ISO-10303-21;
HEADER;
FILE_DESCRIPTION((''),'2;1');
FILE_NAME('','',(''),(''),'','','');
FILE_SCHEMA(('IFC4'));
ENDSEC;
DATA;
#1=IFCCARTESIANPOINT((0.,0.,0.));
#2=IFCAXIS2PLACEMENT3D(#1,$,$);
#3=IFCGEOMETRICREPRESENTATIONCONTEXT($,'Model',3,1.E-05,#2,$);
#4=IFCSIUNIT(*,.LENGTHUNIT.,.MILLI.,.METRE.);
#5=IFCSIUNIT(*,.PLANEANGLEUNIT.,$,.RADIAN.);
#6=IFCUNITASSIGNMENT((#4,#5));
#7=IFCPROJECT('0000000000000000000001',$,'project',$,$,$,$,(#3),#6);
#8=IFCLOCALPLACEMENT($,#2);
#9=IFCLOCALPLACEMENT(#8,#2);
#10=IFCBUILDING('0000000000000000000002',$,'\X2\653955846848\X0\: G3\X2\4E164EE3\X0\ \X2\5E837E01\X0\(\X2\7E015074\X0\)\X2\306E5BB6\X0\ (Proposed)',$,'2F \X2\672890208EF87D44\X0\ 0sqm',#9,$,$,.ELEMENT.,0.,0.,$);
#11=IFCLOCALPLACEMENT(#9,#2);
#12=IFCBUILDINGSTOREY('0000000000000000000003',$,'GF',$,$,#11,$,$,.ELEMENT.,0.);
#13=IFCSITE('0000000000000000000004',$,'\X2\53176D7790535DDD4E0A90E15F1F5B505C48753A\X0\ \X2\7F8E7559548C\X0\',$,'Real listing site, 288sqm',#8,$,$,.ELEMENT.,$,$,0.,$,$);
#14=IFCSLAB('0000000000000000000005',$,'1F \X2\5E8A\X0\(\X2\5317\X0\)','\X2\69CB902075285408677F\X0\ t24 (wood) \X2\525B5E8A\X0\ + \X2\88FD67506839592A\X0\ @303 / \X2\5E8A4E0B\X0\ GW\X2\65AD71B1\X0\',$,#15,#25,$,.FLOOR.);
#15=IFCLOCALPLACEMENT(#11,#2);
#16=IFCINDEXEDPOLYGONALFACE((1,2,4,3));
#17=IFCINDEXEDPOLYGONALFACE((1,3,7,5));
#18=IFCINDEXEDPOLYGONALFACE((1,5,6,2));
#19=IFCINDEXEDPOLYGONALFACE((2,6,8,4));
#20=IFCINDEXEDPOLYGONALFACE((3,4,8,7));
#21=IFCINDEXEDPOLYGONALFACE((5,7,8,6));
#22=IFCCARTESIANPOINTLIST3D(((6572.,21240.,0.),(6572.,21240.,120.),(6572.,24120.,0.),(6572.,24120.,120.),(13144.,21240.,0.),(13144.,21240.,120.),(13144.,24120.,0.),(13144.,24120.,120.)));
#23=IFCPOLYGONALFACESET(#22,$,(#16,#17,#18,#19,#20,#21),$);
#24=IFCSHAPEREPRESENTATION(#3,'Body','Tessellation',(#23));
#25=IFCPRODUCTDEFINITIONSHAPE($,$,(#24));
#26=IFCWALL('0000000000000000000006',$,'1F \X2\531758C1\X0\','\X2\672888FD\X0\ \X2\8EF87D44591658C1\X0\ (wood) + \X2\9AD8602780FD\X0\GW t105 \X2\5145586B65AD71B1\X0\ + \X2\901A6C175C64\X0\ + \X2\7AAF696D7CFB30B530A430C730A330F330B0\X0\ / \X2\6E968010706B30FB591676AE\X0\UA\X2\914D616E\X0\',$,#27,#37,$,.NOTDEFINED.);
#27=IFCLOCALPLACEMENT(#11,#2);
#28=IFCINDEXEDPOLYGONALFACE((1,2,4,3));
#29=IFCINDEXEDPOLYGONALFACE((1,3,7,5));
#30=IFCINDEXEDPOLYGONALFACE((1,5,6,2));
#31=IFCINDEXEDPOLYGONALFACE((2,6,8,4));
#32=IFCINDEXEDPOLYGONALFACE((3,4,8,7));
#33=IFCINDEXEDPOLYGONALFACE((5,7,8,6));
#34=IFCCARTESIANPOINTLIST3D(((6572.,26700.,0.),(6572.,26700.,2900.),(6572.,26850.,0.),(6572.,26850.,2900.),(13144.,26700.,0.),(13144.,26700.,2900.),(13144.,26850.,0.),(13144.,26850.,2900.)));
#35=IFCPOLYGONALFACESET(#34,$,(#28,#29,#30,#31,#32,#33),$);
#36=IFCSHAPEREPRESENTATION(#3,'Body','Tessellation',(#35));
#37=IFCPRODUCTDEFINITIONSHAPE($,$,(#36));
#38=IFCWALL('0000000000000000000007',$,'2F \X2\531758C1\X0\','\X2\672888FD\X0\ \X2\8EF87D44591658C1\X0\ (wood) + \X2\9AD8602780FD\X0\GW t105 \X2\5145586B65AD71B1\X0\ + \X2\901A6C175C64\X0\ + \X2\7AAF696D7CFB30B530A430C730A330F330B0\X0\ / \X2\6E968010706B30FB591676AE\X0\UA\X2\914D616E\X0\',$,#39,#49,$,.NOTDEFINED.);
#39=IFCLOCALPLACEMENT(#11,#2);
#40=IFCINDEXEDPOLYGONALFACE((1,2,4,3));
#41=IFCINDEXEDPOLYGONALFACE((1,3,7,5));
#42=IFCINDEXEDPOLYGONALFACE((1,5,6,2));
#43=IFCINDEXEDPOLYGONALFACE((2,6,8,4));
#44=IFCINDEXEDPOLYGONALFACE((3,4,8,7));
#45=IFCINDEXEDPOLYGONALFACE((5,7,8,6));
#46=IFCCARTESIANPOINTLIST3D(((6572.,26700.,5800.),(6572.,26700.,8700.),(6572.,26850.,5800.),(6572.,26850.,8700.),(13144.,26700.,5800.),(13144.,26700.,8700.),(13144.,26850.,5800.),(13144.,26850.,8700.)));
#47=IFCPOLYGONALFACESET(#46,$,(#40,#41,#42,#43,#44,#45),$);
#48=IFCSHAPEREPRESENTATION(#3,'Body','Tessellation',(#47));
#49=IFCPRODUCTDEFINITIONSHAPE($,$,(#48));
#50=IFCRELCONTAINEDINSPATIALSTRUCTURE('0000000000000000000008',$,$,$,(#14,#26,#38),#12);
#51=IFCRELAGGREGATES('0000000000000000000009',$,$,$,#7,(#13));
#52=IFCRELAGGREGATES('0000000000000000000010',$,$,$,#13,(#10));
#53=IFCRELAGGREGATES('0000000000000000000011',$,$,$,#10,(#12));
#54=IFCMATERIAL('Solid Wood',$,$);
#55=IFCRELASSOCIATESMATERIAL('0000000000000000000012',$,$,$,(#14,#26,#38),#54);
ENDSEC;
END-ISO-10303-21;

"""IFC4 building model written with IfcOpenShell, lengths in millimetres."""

from ifc_helpers import new_model, si_unit, frame, frame_2d, origin, place, context, project, spatial, rectangle, extrude, material, element, save


model = new_model("IFC4")

# Units and contexts
model_context = context("Model", 3, precision=1e-05, world=origin())
ifc_project = project(units=[si_unit("LENGTHUNIT", "METRE", prefix="MILLI"), si_unit("PLANEANGLEUNIT", "RADIAN")], contexts=[model_context])

# Site, building, storey
site_placement = place(None, origin())
site = spatial("IfcSite", under=ifc_project, at=site_placement, Name="北海道川上郡弟子屈町 美留和", ObjectType="Real listing site, 288sqm", CompositionType="ELEMENT", RefElevation=0.0)
building_placement = place(site_placement, origin())
building = spatial("IfcBuilding", under=site, at=building_placement, Name="改善案: G3世代 広縁(縁側)の家 (Proposed)", ObjectType="2F 木造軸組 0sqm", CompositionType="ELEMENT", ElevationOfRefHeight=0.0, ElevationOfTerrain=0.0)
storey_placement = place(building_placement, origin())
storey = spatial("IfcBuildingStorey", under=building, at=storey_placement, Name="GF", CompositionType="ELEMENT", Elevation=0.0)

# Slab
ifc_material_1 = material(Name="Solid Wood")
slab_1_placement = place(storey_placement, frame((3286.0, 10620.0, 0.0)))
element("IfcSlab", 1, at=slab_1_placement, inside=storey, material=ifc_material_1, Name="1F 床(北)", Description="構造用合板 t24 (wood) 剛床 + 製材根太 @303 / 床下 GW断熱", PredefinedType="FLOOR", context=model_context, shape_type="SweptSolid", body=[
    extrude(rectangle(XDim=6572.0, YDim=2880.0, at=frame_2d((3286.0, 1440.0))), frame((3286.0, 10620.0, 0.0)), (0.0, 0.0, 1.0), 120.0),
])

# Wall
wall_1_placement = place(storey_placement, frame((3286.0, 13350.0, 0.0)))
element("IfcWall", 2, at=wall_1_placement, inside=storey, material=ifc_material_1, Name="1F 北壁", Description="木製 軸組外壁 (wood) + 高性能GW t105 充填断熱 + 通気層 + 窯業系サイディング / 準耐火・外皮UA配慮", PredefinedType="NOTDEFINED", context=model_context, shape_type="SweptSolid", body=[
    extrude(rectangle(XDim=6572.0, YDim=150.0, at=frame_2d((3286.0, 75.0))), frame((3286.0, 13350.0, 0.0)), (0.0, 0.0, 1.0), 2900.0),
])

# Wall
wall_2_placement = place(storey_placement, frame((3286.0, 13350.0, 2900.0)))
element("IfcWall", 3, at=wall_2_placement, inside=storey, material=ifc_material_1, Name="2F 北壁", Description="木製 軸組外壁 (wood) + 高性能GW t105 充填断熱 + 通気層 + 窯業系サイディング / 準耐火・外皮UA配慮", PredefinedType="NOTDEFINED", context=model_context, shape_type="SweptSolid", body=[
    extrude(rectangle(XDim=6572.0, YDim=150.0, at=frame_2d((3286.0, 75.0))), frame((3286.0, 13350.0, 2900.0)), (0.0, 0.0, 1.0), 2900.0),
])

save(model, "model.ifc")
